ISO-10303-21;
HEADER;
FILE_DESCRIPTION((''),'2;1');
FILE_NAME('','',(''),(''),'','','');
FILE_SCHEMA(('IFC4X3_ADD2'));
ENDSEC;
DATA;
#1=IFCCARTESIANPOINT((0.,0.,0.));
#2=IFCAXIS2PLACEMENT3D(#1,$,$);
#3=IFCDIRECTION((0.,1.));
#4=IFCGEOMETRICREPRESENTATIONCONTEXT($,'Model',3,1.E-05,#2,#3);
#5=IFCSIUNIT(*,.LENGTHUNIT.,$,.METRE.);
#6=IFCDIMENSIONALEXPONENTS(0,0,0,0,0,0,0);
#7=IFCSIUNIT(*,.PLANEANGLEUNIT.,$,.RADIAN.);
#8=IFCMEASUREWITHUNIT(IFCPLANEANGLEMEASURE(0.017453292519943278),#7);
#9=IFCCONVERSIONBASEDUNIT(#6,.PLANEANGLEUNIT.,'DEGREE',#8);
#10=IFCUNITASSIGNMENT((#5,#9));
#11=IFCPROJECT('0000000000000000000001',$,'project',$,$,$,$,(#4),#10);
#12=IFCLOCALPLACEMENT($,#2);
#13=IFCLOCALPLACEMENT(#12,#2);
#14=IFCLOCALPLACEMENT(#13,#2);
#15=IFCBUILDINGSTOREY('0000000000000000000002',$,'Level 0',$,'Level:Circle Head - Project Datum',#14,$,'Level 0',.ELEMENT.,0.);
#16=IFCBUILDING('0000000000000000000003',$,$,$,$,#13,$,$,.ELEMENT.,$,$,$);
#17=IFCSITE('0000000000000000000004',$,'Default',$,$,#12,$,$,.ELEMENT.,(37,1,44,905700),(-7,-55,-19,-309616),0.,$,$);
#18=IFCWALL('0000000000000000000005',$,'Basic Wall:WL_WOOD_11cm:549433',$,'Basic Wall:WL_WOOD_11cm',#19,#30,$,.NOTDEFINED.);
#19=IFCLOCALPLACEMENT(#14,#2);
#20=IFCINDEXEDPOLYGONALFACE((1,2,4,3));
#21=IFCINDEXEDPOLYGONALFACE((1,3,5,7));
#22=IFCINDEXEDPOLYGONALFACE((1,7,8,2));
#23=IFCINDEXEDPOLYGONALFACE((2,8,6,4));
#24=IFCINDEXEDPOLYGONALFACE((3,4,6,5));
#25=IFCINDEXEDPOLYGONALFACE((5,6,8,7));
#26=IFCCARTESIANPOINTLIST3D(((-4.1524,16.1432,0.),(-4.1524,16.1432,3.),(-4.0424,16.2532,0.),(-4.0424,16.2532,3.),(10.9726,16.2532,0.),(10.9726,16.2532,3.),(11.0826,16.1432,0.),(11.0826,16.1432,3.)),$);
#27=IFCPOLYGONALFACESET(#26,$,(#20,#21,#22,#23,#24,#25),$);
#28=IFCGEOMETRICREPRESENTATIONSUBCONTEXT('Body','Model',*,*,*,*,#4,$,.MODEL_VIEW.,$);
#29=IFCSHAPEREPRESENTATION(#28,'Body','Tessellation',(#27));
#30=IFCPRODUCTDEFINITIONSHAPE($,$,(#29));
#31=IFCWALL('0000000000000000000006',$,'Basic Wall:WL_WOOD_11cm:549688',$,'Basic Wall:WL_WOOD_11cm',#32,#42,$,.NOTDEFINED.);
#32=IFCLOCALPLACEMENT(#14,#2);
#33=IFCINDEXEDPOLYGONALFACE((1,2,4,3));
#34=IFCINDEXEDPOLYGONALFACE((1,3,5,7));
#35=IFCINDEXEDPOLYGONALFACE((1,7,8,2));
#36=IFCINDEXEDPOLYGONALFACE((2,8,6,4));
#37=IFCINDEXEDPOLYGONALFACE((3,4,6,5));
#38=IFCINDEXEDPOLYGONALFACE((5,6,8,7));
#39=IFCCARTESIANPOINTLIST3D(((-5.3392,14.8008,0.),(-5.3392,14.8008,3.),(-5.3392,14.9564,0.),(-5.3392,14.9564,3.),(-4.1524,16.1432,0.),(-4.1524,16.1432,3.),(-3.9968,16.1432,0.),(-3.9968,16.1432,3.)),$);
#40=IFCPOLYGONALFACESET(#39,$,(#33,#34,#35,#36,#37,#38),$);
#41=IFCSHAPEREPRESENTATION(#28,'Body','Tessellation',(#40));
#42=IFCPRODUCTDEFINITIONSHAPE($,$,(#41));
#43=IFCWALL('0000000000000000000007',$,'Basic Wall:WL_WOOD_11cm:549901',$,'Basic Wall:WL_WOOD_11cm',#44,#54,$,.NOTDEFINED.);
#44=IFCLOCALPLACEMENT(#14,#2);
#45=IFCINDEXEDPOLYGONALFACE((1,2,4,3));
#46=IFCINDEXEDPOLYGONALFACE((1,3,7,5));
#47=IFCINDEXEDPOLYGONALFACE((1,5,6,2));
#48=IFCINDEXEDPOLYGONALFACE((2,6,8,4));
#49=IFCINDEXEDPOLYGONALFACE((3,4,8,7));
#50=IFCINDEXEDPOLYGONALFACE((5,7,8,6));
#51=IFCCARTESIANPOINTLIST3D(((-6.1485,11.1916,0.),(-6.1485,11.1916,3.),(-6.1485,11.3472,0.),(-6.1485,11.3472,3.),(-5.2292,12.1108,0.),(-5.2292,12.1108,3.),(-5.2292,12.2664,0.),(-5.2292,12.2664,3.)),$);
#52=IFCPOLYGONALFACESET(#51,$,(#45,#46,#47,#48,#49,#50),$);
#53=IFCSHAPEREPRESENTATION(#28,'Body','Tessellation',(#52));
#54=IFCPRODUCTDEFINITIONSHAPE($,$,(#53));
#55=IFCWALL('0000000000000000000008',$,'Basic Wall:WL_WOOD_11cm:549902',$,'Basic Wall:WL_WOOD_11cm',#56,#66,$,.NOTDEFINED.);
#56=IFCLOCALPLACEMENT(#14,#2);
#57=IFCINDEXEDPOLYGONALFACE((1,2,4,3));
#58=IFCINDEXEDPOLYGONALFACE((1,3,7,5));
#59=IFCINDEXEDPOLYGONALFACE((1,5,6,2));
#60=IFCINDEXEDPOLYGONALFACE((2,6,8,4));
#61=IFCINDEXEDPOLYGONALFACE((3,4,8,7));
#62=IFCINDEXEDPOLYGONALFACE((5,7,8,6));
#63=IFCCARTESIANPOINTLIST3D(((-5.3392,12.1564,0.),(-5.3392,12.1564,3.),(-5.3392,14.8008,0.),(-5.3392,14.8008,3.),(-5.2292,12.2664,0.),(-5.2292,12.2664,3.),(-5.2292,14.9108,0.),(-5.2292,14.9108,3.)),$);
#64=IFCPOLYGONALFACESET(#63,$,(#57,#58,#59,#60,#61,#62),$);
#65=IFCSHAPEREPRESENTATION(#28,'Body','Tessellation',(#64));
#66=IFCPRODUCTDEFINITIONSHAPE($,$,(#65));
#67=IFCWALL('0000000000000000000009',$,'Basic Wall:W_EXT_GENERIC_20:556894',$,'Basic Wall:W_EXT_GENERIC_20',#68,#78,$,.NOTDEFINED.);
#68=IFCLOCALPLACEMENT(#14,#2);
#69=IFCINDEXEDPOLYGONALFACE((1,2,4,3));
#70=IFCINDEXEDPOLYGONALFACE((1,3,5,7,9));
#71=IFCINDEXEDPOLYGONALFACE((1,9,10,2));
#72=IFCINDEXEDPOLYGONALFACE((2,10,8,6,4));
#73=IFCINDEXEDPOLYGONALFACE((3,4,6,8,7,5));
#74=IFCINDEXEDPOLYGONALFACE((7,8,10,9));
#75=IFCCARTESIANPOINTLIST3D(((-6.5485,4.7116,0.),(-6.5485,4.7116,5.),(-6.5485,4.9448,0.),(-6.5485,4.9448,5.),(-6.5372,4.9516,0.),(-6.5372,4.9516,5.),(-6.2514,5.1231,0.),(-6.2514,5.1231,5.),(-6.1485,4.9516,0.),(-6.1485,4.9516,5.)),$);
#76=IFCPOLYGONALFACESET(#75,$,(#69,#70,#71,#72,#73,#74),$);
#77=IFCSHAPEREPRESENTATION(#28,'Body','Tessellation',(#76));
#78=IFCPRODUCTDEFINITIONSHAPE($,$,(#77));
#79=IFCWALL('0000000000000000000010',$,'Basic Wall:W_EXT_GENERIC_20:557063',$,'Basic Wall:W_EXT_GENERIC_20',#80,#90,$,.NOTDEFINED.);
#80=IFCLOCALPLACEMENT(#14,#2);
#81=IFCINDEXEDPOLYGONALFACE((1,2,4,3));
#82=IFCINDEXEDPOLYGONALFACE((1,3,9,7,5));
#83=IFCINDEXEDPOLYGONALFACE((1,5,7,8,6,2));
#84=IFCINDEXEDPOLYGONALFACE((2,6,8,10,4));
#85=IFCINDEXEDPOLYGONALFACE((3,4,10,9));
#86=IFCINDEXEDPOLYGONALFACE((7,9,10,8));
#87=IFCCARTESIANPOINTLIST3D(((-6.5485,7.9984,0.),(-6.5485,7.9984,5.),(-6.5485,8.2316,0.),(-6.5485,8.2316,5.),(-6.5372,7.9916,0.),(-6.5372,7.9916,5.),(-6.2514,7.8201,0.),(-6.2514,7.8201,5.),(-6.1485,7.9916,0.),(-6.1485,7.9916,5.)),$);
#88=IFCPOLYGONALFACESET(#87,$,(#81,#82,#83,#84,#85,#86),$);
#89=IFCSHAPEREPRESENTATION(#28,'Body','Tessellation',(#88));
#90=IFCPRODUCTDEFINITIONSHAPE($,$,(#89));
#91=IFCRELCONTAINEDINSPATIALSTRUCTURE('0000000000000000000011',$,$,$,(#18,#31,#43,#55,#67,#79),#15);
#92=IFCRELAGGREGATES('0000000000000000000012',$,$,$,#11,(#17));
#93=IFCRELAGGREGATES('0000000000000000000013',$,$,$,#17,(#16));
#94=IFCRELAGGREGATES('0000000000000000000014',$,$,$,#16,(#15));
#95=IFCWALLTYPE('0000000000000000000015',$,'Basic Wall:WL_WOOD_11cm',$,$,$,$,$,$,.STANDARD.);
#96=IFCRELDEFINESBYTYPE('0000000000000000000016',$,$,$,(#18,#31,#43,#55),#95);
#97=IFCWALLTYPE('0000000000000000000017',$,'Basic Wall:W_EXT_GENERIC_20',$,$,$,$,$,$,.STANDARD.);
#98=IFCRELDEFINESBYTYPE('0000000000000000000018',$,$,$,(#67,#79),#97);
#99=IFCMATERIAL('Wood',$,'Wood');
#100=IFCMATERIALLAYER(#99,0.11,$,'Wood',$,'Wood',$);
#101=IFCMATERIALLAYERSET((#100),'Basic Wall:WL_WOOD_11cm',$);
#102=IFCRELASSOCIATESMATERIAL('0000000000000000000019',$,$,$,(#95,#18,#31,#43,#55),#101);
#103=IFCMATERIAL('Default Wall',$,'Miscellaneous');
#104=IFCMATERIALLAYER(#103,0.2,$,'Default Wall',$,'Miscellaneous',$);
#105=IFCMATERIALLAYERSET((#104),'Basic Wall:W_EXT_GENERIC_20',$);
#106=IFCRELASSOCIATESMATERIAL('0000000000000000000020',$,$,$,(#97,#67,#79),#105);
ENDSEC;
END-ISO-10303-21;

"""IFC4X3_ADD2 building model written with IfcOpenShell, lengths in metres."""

from ifc_helpers import new_model, entity, si_unit, converted_unit, direction, frame, origin, place, context, subcontext, project, spatial, polyline, outline, extrude, clip, bounded_halfspace, material, layer, layer_set, type_object, element, save


model = new_model("IFC4X3_ADD2")

# Units and contexts
model_context = context("Model", 3, precision=1e-05, world=origin(), true_north=direction((0.0, 1.0)))
body_context = subcontext(model_context, "Body", "Model", "MODEL_VIEW")
ifc_project = project(units=[si_unit("LENGTHUNIT", "METRE"), converted_unit("PLANEANGLEUNIT", "DEGREE", entity("IfcPlaneAngleMeasure", 0.017453292519943278), si_unit("PLANEANGLEUNIT", "RADIAN"), dimensions=[0, 0, 0, 0, 0, 0, 0])], contexts=[model_context])

# Site, building, storey
site_placement = place(None, origin())
site = spatial("IfcSite", under=ifc_project, at=site_placement, Name="Default", CompositionType="ELEMENT", RefLatitude=(37, 1, 44, 905700), RefLongitude=(-7, -55, -19, -309616), RefElevation=0.0)
building_placement = place(site_placement, origin())
building = spatial("IfcBuilding", under=site, at=building_placement, CompositionType="ELEMENT")
storey_placement = place(building_placement, origin())
storey = spatial("IfcBuildingStorey", under=building, at=storey_placement, Name="Level 0", ObjectType="Level:Circle Head - Project Datum", LongName="Level 0", CompositionType="ELEMENT", Elevation=0.0)

# Shared definitions
ifc_material_1 = material(Name="Default Wall", Category="Miscellaneous")

# Walls
ifc_material_2 = material(Name="Wood", Category="Wood")
ifc_layer_1 = layer(ifc_material_2, 0.11, Name="Wood", Category="Wood")
ifc_layer_set_1 = layer_set([ifc_layer_1], Name="Basic Wall:WL_WOOD_11cm")
wall_type_1 = type_object("IfcWallType", Name="Basic Wall:WL_WOOD_11cm", PredefinedType="STANDARD", material=ifc_layer_set_1)
wall_1_placement = place(storey_placement, frame((-4.1524, 16.1982, 0.0)))
element("IfcWall", 1, at=wall_1_placement, inside=storey, type_object=wall_type_1, material=ifc_layer_set_1, Name="Basic Wall:WL_WOOD_11cm:549433", ObjectType="Basic Wall:WL_WOOD_11cm", PredefinedType="NOTDEFINED", context=body_context, shape_type="Clipping", body=[
    clip(extrude(outline(polyline([(15.235, -0.055), (15.125, 0.055), (0.11, 0.055), (0.0, -0.055), (0.1556, -0.055), (15.235, -0.055)])), origin(), (0.0, 0.0, 1.0), 3.0), bounded_halfspace(frame((0.0, -0.055, 3.0), z_axis=(0.0, 0.0, -1.0), x_axis=(1.0, 0.0, 0.0)), True, frame((0.0, -0.055, 3.0)), polyline([(0.0, 0.0), (0.1556, 0.0), (15.235, 0.0), (15.125, 0.11), (0.11, 0.11), (0.0, 0.0)]))),
])
wall_2_placement = place(storey_placement, frame((-5.3781, 14.8397, 0.0), z_axis=(0.0, 0.0, 1.0), x_axis=(0.707107, 0.707107, 0.0)))
element("IfcWall", 2, at=wall_2_placement, inside=storey, type_object=wall_type_1, material=ifc_layer_set_1, Name="Basic Wall:WL_WOOD_11cm:549688", ObjectType="Basic Wall:WL_WOOD_11cm", PredefinedType="NOTDEFINED", context=body_context, shape_type="Clipping", body=[
    clip(extrude(outline(polyline([(1.8985, -0.055), (1.7885, 0.055), (0.11, 0.055), (0.0, -0.055), (0.1556, -0.055), (1.8985, -0.055)])), origin(), (0.0, 0.0, 1.0), 3.0), bounded_halfspace(frame((0.0, -0.055, 3.0), z_axis=(0.0, 0.0, -1.0), x_axis=(0.707107, -0.707107, 0.0)), True, frame((0.0, -0.055, 3.0)), polyline([(0.0, 0.0), (0.1556, 0.0), (1.8985, 0.0), (1.7885, 0.11), (0.11, 0.11), (0.0, 0.0)]))),
])
wall_3_placement = place(storey_placement, frame((-6.1874, 11.2305, 0.0), z_axis=(0.0, 0.0, 1.0), x_axis=(0.707107, 0.707107, 0.0)))
element("IfcWall", 3, at=wall_3_placement, inside=storey, type_object=wall_type_1, material=ifc_layer_set_1, Name="Basic Wall:WL_WOOD_11cm:549901", ObjectType="Basic Wall:WL_WOOD_11cm", PredefinedType="NOTDEFINED", context=body_context, shape_type="Clipping", body=[
    clip(extrude(outline(polyline([(1.3, -0.055), (1.41, 0.055), (1.2544, 0.055), (0.11, 0.055), (0.0, -0.055), (1.3, -0.055)])), origin(), (0.0, 0.0, 1.0), 3.0), bounded_halfspace(frame((0.0, -0.055, 3.0), z_axis=(0.0, 0.0, -1.0), x_axis=(0.707107, -0.707107, 0.0)), True, frame((0.0, -0.055, 3.0)), polyline([(0.0, 0.0), (1.3, 0.0), (1.41, 0.11), (1.2544, 0.11), (0.11, 0.11), (0.0, 0.0)]))),
])
wall_4_placement = place(storey_placement, frame((-5.2842, 12.1564, 0.0), z_axis=(0.0, 0.0, 1.0), x_axis=(0.0, 1.0, 0.0)))
element("IfcWall", 4, at=wall_4_placement, inside=storey, type_object=wall_type_1, material=ifc_layer_set_1, Name="Basic Wall:WL_WOOD_11cm:549902", ObjectType="Basic Wall:WL_WOOD_11cm", PredefinedType="NOTDEFINED", context=body_context, shape_type="Clipping", body=[
    clip(extrude(outline(polyline([(2.7544, -0.055), (2.6444, 0.055), (0.0, 0.055), (0.11, -0.055), (2.7544, -0.055)])), origin(), (0.0, 0.0, 1.0), 3.0), bounded_halfspace(frame((0.11, -0.055, 3.0), z_axis=(0.0, 0.0, -1.0), x_axis=(0.0, -1.0, 0.0)), True, frame((0.11, -0.055, 3.0)), polyline([(0.0, 0.0), (2.6444, 0.0), (2.5344, 0.11), (-0.11, 0.11), (0.0, 0.0)]))),
])
ifc_layer_2 = layer(ifc_material_1, 0.2, Name="Default Wall", Category="Miscellaneous")
ifc_layer_set_2 = layer_set([ifc_layer_2], Name="Basic Wall:W_EXT_GENERIC_20")
wall_type_2 = type_object("IfcWallType", Name="Basic Wall:W_EXT_GENERIC_20", PredefinedType="STANDARD", material=ifc_layer_set_2)
wall_5_placement = place(storey_placement, frame((-6.1999, 5.0373, 0.0), z_axis=(0.0, 0.0, 1.0), x_axis=(-0.857493, -0.514496, 0.0)))
element("IfcWall", 5, at=wall_5_placement, inside=storey, type_object=wall_type_2, material=ifc_layer_set_2, Name="Basic Wall:W_EXT_GENERIC_20:556894", ObjectType="Basic Wall:W_EXT_GENERIC_20", PredefinedType="NOTDEFINED", context=body_context, shape_type="SweptSolid", body=[
    extrude(outline(polyline([(0.3465, -0.1), (0.4665, 0.1), (0.0, 0.1), (0.0, -0.1), (0.3333, -0.1), (0.3465, -0.1)])), origin(), (0.0, 0.0, 1.0), 5.0),
])
wall_6_placement = place(storey_placement, frame((-6.1999, 7.9058, 0.0), z_axis=(0.0, 0.0, 1.0), x_axis=(-0.857493, 0.514496, 0.0)))
element("IfcWall", 6, at=wall_6_placement, inside=storey, type_object=wall_type_2, material=ifc_layer_set_2, Name="Basic Wall:W_EXT_GENERIC_20:557063", ObjectType="Basic Wall:W_EXT_GENERIC_20", PredefinedType="NOTDEFINED", context=body_context, shape_type="SweptSolid", body=[
    extrude(outline(polyline([(0.4665, -0.1), (0.3465, 0.1), (0.3333, 0.1), (0.0, 0.1), (0.0, -0.1), (0.4665, -0.1)])), origin(), (0.0, 0.0, 1.0), 5.0),
])

save(model, "model.ifc")
